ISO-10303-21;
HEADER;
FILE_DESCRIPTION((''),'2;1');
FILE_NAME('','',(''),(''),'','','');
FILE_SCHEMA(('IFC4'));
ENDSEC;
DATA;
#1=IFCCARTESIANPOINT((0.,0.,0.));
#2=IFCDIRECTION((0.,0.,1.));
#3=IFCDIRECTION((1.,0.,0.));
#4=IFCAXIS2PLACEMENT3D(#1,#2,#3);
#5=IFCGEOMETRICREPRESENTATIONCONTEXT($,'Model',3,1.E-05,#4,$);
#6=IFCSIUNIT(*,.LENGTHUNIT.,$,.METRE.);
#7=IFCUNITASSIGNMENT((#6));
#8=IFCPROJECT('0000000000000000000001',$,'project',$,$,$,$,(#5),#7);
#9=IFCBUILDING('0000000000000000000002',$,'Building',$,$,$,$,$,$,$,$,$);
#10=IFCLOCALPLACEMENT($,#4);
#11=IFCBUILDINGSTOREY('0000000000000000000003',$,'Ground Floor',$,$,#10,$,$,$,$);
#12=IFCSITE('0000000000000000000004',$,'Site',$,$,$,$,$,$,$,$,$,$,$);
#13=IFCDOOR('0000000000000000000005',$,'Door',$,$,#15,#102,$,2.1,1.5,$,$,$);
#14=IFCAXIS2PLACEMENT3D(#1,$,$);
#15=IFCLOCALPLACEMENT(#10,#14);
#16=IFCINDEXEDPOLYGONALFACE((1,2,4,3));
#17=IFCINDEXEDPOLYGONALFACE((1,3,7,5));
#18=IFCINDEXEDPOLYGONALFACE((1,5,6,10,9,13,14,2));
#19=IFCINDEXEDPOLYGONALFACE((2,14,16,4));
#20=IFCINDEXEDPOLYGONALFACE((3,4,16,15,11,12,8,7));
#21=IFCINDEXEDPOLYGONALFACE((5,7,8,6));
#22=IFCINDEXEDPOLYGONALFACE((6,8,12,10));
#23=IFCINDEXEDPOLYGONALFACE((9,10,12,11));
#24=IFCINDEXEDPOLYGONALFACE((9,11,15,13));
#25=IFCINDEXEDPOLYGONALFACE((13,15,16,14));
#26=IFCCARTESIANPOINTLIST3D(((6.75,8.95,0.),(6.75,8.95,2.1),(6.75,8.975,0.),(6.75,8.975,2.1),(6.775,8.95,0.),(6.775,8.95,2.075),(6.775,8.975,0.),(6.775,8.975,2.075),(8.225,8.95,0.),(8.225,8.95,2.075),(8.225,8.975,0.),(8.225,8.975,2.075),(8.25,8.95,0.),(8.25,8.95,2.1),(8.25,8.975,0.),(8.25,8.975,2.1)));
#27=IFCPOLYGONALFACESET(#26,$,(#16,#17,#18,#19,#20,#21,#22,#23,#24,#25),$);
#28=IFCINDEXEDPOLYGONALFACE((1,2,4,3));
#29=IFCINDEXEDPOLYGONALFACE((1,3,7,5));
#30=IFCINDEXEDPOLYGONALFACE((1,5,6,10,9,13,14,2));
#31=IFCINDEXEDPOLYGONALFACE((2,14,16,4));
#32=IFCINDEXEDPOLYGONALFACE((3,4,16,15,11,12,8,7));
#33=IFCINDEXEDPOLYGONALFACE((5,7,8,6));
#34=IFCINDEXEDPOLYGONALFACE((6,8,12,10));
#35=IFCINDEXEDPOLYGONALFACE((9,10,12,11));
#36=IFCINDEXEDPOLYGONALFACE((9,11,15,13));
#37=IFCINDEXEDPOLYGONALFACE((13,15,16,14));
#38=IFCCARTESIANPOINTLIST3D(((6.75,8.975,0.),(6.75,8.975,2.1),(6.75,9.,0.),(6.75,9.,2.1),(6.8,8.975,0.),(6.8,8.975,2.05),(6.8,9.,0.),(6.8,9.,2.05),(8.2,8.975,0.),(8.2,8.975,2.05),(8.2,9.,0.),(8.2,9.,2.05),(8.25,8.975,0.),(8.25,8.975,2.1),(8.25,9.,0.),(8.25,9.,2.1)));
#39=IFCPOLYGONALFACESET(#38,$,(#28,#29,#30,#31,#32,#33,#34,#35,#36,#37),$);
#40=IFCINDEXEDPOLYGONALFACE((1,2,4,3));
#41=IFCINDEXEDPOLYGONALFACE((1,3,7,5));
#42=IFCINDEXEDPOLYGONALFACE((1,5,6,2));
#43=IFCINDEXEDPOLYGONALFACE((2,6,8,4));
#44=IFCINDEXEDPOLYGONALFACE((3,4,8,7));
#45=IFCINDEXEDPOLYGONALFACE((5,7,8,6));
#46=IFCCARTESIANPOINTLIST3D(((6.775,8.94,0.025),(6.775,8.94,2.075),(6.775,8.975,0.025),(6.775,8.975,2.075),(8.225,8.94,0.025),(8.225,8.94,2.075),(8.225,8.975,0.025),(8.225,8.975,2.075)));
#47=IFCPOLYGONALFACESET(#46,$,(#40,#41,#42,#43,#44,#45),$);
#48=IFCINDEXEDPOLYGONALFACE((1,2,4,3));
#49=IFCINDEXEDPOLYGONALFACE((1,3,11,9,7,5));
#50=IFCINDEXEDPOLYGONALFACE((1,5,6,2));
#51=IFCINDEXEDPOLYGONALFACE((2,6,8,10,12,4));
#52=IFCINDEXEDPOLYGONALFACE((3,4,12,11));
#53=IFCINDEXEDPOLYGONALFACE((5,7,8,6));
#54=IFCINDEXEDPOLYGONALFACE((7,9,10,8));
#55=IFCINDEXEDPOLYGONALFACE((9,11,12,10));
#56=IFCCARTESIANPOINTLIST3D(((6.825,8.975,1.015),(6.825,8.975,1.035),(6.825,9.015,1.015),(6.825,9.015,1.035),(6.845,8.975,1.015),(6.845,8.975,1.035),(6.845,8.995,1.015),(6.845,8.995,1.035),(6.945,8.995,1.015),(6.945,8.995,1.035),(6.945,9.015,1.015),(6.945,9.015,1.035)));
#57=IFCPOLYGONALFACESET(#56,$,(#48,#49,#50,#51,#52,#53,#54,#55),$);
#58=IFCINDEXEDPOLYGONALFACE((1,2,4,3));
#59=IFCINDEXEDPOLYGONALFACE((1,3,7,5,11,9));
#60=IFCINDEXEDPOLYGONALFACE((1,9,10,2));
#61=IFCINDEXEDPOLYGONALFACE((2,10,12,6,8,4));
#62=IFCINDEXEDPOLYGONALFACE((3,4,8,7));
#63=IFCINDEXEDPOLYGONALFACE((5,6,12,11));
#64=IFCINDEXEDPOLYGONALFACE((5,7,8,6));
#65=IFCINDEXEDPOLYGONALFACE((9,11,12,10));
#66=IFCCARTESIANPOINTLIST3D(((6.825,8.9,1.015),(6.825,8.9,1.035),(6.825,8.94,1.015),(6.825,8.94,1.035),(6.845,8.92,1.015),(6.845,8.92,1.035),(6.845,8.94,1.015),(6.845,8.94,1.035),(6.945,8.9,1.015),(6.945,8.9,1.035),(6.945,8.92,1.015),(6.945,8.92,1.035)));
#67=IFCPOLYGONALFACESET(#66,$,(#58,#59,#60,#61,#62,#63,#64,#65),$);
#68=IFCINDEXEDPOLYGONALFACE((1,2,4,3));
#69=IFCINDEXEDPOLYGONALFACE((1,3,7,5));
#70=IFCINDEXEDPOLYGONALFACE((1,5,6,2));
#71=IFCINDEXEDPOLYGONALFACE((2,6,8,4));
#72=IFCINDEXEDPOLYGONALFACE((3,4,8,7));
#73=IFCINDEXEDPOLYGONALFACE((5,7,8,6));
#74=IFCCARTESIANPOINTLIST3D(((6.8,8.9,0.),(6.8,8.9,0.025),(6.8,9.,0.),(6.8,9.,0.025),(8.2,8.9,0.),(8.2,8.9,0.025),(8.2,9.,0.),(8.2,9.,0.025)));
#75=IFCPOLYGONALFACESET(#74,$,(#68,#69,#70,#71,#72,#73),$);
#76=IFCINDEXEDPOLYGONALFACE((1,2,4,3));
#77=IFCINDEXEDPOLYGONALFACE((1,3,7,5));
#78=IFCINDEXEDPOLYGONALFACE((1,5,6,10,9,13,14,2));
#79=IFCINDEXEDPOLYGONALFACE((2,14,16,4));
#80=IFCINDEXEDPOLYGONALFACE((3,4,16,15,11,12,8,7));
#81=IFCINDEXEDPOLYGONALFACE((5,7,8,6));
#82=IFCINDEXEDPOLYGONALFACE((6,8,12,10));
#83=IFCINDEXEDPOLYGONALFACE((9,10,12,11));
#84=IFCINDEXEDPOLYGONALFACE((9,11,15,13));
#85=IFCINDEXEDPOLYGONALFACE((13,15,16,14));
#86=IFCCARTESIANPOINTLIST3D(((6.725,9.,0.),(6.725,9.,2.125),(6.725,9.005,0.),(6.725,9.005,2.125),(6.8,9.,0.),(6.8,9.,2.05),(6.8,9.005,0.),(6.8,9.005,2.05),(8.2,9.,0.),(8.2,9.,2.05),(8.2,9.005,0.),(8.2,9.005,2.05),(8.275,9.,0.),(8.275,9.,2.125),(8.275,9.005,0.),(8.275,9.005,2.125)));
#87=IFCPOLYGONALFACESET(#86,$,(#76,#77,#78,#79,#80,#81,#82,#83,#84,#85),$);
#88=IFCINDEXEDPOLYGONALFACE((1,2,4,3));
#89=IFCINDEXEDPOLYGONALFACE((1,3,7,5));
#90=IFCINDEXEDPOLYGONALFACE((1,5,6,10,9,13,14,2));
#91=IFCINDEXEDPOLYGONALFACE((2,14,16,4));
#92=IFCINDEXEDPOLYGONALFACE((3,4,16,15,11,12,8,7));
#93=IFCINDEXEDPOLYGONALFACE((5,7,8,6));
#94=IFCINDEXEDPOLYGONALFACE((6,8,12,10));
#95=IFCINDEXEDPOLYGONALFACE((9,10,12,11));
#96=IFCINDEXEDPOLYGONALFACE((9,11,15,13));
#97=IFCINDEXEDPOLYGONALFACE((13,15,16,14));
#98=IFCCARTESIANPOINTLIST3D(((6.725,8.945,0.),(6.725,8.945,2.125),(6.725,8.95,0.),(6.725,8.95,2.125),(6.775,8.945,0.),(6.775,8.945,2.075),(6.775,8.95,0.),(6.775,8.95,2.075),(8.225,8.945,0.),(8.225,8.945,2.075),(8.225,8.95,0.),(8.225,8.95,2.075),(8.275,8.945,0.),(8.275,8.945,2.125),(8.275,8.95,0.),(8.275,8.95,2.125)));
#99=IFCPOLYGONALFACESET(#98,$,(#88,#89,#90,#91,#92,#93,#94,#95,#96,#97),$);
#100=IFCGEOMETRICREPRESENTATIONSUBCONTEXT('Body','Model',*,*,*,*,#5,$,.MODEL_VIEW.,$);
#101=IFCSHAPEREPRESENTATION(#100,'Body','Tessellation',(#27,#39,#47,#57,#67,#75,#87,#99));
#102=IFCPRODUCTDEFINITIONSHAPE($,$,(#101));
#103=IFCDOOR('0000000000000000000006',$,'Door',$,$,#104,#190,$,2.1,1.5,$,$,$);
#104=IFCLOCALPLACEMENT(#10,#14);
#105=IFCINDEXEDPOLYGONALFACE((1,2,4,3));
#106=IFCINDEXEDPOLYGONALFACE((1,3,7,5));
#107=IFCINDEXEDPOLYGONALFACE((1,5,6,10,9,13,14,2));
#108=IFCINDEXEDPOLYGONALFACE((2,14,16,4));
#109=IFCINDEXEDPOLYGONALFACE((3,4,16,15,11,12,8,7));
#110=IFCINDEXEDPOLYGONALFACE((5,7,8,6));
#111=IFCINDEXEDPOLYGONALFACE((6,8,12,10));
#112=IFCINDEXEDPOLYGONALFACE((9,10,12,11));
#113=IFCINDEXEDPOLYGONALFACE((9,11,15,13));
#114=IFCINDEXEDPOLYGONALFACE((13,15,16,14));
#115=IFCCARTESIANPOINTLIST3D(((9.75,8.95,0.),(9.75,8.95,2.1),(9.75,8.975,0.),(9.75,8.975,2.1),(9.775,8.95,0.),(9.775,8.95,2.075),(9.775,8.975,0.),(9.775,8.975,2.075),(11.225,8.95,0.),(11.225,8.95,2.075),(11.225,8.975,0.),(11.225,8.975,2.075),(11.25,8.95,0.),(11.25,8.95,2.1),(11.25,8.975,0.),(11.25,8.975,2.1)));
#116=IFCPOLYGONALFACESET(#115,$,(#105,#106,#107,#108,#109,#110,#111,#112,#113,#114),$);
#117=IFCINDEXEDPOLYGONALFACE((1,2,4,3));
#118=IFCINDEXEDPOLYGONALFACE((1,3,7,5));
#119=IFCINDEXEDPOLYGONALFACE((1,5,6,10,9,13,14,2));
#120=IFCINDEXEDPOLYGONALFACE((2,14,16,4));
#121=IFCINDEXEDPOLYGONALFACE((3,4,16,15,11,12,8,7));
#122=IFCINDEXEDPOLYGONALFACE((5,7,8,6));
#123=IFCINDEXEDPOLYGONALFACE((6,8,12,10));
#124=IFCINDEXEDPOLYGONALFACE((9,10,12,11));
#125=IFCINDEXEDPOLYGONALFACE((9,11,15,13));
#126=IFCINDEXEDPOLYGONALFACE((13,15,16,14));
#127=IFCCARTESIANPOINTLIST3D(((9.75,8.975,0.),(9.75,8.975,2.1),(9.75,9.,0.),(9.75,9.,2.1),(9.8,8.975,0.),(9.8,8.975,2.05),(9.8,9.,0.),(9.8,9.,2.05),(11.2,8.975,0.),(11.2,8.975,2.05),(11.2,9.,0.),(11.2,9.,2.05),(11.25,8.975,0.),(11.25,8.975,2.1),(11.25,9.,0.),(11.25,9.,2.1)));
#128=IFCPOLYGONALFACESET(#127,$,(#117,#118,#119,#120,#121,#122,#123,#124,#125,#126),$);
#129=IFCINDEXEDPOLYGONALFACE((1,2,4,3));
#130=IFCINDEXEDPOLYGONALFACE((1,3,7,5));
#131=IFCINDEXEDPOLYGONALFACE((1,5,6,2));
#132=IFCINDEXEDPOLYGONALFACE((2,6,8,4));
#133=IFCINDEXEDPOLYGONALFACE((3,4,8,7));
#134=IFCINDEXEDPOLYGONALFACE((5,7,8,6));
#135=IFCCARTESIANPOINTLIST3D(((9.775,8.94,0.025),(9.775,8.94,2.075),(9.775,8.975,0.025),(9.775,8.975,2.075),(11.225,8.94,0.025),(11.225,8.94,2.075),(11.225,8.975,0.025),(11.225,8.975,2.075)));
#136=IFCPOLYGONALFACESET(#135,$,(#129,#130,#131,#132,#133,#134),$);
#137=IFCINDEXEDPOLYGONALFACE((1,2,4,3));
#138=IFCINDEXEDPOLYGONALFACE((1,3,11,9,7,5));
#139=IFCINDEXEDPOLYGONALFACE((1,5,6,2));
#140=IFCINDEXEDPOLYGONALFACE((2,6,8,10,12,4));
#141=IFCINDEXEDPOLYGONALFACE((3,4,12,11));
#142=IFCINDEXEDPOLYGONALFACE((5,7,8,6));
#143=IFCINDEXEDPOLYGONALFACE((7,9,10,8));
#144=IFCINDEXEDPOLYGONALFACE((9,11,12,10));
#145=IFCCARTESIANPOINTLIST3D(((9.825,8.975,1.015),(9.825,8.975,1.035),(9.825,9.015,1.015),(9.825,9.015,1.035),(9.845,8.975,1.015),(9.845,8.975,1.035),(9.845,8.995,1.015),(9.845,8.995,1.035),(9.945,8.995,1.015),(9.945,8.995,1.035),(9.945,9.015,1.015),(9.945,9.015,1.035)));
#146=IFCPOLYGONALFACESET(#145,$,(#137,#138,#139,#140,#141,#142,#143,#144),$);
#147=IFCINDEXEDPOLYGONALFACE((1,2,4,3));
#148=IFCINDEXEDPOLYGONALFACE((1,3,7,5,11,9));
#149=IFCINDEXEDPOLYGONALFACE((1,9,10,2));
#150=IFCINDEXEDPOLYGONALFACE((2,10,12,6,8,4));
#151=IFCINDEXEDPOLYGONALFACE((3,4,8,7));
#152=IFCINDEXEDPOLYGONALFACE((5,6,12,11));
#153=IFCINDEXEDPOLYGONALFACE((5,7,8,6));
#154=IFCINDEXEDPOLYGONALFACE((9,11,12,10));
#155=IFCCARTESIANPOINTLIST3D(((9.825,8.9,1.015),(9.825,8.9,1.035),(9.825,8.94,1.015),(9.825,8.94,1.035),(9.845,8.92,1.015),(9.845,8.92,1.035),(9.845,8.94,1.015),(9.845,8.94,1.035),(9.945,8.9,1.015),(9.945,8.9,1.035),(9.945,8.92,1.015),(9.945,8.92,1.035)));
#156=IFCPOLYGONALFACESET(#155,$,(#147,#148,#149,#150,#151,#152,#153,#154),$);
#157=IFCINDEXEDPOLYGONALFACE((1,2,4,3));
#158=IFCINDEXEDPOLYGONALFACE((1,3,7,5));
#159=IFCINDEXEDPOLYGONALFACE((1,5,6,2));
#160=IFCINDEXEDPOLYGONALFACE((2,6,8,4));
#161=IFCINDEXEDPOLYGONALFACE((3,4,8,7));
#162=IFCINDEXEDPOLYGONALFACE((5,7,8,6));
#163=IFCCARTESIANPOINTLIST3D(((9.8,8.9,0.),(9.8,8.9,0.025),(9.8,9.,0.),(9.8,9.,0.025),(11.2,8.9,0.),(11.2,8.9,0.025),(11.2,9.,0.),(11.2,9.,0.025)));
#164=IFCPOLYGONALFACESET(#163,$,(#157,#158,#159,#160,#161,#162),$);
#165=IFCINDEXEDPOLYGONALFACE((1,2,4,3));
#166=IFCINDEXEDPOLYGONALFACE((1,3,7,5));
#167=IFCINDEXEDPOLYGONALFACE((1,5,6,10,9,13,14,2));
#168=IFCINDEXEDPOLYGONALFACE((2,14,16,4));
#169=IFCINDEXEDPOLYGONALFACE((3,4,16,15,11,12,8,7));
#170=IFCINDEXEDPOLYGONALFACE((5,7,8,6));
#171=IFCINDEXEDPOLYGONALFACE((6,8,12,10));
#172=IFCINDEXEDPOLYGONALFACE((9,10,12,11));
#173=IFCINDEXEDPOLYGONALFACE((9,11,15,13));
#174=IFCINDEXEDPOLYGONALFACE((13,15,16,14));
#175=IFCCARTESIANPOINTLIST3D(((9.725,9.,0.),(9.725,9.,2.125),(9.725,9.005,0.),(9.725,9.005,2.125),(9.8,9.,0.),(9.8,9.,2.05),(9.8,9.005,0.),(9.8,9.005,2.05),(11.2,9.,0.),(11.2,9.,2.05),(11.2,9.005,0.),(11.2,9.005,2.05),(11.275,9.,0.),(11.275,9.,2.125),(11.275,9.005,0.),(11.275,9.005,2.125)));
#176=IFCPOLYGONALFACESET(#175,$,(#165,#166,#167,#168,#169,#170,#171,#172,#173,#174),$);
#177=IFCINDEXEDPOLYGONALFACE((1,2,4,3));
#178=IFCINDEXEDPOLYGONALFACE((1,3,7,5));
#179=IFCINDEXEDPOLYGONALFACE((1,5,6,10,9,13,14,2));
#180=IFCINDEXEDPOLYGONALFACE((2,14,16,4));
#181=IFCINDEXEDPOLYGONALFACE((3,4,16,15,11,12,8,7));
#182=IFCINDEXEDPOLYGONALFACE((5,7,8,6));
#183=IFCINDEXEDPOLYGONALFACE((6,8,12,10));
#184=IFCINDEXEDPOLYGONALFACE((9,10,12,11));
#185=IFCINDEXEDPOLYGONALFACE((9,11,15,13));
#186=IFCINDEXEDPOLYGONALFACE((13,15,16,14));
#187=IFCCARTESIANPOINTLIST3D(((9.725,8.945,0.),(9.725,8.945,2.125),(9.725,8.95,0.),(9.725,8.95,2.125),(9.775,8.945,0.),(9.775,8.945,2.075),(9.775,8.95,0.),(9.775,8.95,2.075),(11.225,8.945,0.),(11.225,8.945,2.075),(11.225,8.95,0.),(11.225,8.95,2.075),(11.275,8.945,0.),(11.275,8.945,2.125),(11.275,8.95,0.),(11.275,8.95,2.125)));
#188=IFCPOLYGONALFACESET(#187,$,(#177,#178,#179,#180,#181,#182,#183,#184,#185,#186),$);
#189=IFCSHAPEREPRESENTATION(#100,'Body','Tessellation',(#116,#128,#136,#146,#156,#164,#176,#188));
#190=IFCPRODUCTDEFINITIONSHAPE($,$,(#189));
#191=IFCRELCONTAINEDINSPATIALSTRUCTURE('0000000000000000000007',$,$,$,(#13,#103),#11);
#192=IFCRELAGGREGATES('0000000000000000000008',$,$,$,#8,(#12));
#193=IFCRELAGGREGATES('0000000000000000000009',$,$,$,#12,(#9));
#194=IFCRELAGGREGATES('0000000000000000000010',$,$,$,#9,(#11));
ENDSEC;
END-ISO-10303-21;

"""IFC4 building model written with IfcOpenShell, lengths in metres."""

from ifc_helpers import new_model, si_unit, frame, origin_with_axes, place, context, subcontext, project, spatial, line, indexed_curve, outline, extrude, element, save


model = new_model("IFC4")

# Units and contexts
model_context = context("Model", 3, precision=1e-05, world=origin_with_axes())
body_context = subcontext(model_context, "Body", "Model", "MODEL_VIEW")
ifc_project = project(units=[si_unit("LENGTHUNIT", "METRE")], contexts=[model_context])

# Site, building, storey
site = spatial("IfcSite", under=ifc_project, Name="Site")
building = spatial("IfcBuilding", under=site, Name="Building")
storey_placement = place(None, origin_with_axes())
storey = spatial("IfcBuildingStorey", under=building, at=storey_placement, Name="Ground Floor")

# Doors
door_1_placement = place(storey_placement, frame((8.25, 9.0, 0.0), z_axis=(0.0, 0.0, 1.0), x_axis=(-1.0, 0.0, 0.0)))
element("IfcDoor", 1, at=door_1_placement, inside=storey, Name="Door", OverallHeight=2.1, OverallWidth=1.5, context=body_context, shape_type="SweptSolid", body=[
    extrude(outline(indexed_curve([(0.0, 0.0), (0.0, 2.1), (1.5, 2.1), (1.5, 0.0), (1.475, 0.0), (1.475, 2.075), (0.025, 2.075), (0.025, 0.0)], segments=[line(1, 2, 3, 4, 5, 6, 7, 8, 1)])), frame((0.0, 0.025, 0.0), z_axis=(0.0, -1.0, 0.0), x_axis=(1.0, 0.0, 0.0)), (0.0, 0.0, -1.0), 0.025),
    extrude(outline(indexed_curve([(0.0, 0.0), (0.0, 2.1), (1.5, 2.1), (1.5, 0.0), (1.45, 0.0), (1.45, 2.05), (0.05, 2.05), (0.05, 0.0)], segments=[line(1, 2, 3, 4, 5, 6, 7, 8, 1)])), frame((0.0, 0.0, 0.0), z_axis=(0.0, -1.0, 0.0), x_axis=(1.0, 0.0, 0.0)), (0.0, 0.0, -1.0), 0.025),
    extrude(outline(indexed_curve([(0.0, 0.0), (1.45, 0.0), (1.45, 0.035), (0.0, 0.035)], segments=[line(1, 2, 3, 4, 1)])), frame((0.025, 0.025, 0.025), z_axis=(0.0, 0.0, 1.0), x_axis=(1.0, 0.0, 0.0)), (0.0, 0.0, 1.0), 2.05),
    extrude(outline(indexed_curve([(0.0, 0.0), (0.0, -0.04), (-0.12, -0.04), (-0.12, -0.02), (-0.02, -0.02), (-0.02, 0.0)], segments=[line(1, 2, 3, 4, 5, 6, 1)])), frame((1.425, 0.025, 1.015), z_axis=(0.0, 0.0, 1.0), x_axis=(1.0, 0.0, 0.0)), (0.0, 0.0, 1.0), 0.02),
    extrude(outline(indexed_curve([(0.0, 0.0), (0.0, 0.04), (-0.12, 0.04), (-0.12, 0.02), (-0.02, 0.02), (-0.02, 0.0)], segments=[line(1, 2, 3, 4, 5, 6, 1)])), frame((1.425, 0.06, 1.015), z_axis=(0.0, 0.0, 1.0), x_axis=(1.0, 0.0, 0.0)), (0.0, 0.0, 1.0), 0.02),
    extrude(outline(indexed_curve([(0.0, 0.0), (1.4, 0.0), (1.4, 0.1), (0.0, 0.1)], segments=[line(1, 2, 3, 4, 1)])), frame((0.05, 0.0, 0.0), z_axis=(0.0, 0.0, 1.0), x_axis=(1.0, 0.0, 0.0)), (0.0, 0.0, 1.0), 0.025),
    extrude(outline(indexed_curve([(0.0, 0.0), (0.0, 2.125), (1.55, 2.125), (1.55, 0.0), (1.475, 0.0), (1.475, 2.05), (0.075, 2.05), (0.075, 0.0)], segments=[line(1, 2, 3, 4, 5, 6, 7, 8, 1)])), frame((-0.025, -0.005, 0.0), z_axis=(0.0, -1.0, 0.0), x_axis=(1.0, 0.0, 0.0)), (0.0, 0.0, -1.0), 0.005),
    extrude(outline(indexed_curve([(0.0, 0.0), (0.0, 2.125), (1.55, 2.125), (1.55, 0.0), (1.5, 0.0), (1.5, 2.075), (0.05, 2.075), (0.05, 0.0)], segments=[line(1, 2, 3, 4, 5, 6, 7, 8, 1)])), frame((-0.025, 0.05, 0.0), z_axis=(0.0, -1.0, 0.0), x_axis=(1.0, 0.0, 0.0)), (0.0, 0.0, -1.0), 0.005),
])
door_2_placement = place(storey_placement, frame((11.25, 9.0, 0.0), z_axis=(0.0, 0.0, 1.0), x_axis=(-1.0, 0.0, 0.0)))
element("IfcDoor", 2, at=door_2_placement, inside=storey, Name="Door", OverallHeight=2.1, OverallWidth=1.5, context=body_context, shape_type="SweptSolid", body=[
    extrude(outline(indexed_curve([(0.0, 0.0), (0.0, 2.1), (1.5, 2.1), (1.5, 0.0), (1.475, 0.0), (1.475, 2.075), (0.025, 2.075), (0.025, 0.0)], segments=[line(1, 2, 3, 4, 5, 6, 7, 8, 1)])), frame((0.0, 0.025, 0.0), z_axis=(0.0, -1.0, 0.0), x_axis=(1.0, 0.0, 0.0)), (0.0, 0.0, -1.0), 0.025),
    extrude(outline(indexed_curve([(0.0, 0.0), (0.0, 2.1), (1.5, 2.1), (1.5, 0.0), (1.45, 0.0), (1.45, 2.05), (0.05, 2.05), (0.05, 0.0)], segments=[line(1, 2, 3, 4, 5, 6, 7, 8, 1)])), frame((0.0, 0.0, 0.0), z_axis=(0.0, -1.0, 0.0), x_axis=(1.0, 0.0, 0.0)), (0.0, 0.0, -1.0), 0.025),
    extrude(outline(indexed_curve([(0.0, 0.0), (1.45, 0.0), (1.45, 0.035), (0.0, 0.035)], segments=[line(1, 2, 3, 4, 1)])), frame((0.025, 0.025, 0.025), z_axis=(0.0, 0.0, 1.0), x_axis=(1.0, 0.0, 0.0)), (0.0, 0.0, 1.0), 2.05),
    extrude(outline(indexed_curve([(0.0, 0.0), (0.0, -0.04), (-0.12, -0.04), (-0.12, -0.02), (-0.02, -0.02), (-0.02, 0.0)], segments=[line(1, 2, 3, 4, 5, 6, 1)])), frame((1.425, 0.025, 1.015), z_axis=(0.0, 0.0, 1.0), x_axis=(1.0, 0.0, 0.0)), (0.0, 0.0, 1.0), 0.02),
    extrude(outline(indexed_curve([(0.0, 0.0), (0.0, 0.04), (-0.12, 0.04), (-0.12, 0.02), (-0.02, 0.02), (-0.02, 0.0)], segments=[line(1, 2, 3, 4, 5, 6, 1)])), frame((1.425, 0.06, 1.015), z_axis=(0.0, 0.0, 1.0), x_axis=(1.0, 0.0, 0.0)), (0.0, 0.0, 1.0), 0.02),
    extrude(outline(indexed_curve([(0.0, 0.0), (1.4, 0.0), (1.4, 0.1), (0.0, 0.1)], segments=[line(1, 2, 3, 4, 1)])), frame((0.05, 0.0, 0.0), z_axis=(0.0, 0.0, 1.0), x_axis=(1.0, 0.0, 0.0)), (0.0, 0.0, 1.0), 0.025),
    extrude(outline(indexed_curve([(0.0, 0.0), (0.0, 2.125), (1.55, 2.125), (1.55, 0.0), (1.475, 0.0), (1.475, 2.05), (0.075, 2.05), (0.075, 0.0)], segments=[line(1, 2, 3, 4, 5, 6, 7, 8, 1)])), frame((-0.025, -0.005, 0.0), z_axis=(0.0, -1.0, 0.0), x_axis=(1.0, 0.0, 0.0)), (0.0, 0.0, -1.0), 0.005),
    extrude(outline(indexed_curve([(0.0, 0.0), (0.0, 2.125), (1.55, 2.125), (1.55, 0.0), (1.5, 0.0), (1.5, 2.075), (0.05, 2.075), (0.05, 0.0)], segments=[line(1, 2, 3, 4, 5, 6, 7, 8, 1)])), frame((-0.025, 0.05, 0.0), z_axis=(0.0, -1.0, 0.0), x_axis=(1.0, 0.0, 0.0)), (0.0, 0.0, -1.0), 0.005),
])

save(model, "model.ifc")
